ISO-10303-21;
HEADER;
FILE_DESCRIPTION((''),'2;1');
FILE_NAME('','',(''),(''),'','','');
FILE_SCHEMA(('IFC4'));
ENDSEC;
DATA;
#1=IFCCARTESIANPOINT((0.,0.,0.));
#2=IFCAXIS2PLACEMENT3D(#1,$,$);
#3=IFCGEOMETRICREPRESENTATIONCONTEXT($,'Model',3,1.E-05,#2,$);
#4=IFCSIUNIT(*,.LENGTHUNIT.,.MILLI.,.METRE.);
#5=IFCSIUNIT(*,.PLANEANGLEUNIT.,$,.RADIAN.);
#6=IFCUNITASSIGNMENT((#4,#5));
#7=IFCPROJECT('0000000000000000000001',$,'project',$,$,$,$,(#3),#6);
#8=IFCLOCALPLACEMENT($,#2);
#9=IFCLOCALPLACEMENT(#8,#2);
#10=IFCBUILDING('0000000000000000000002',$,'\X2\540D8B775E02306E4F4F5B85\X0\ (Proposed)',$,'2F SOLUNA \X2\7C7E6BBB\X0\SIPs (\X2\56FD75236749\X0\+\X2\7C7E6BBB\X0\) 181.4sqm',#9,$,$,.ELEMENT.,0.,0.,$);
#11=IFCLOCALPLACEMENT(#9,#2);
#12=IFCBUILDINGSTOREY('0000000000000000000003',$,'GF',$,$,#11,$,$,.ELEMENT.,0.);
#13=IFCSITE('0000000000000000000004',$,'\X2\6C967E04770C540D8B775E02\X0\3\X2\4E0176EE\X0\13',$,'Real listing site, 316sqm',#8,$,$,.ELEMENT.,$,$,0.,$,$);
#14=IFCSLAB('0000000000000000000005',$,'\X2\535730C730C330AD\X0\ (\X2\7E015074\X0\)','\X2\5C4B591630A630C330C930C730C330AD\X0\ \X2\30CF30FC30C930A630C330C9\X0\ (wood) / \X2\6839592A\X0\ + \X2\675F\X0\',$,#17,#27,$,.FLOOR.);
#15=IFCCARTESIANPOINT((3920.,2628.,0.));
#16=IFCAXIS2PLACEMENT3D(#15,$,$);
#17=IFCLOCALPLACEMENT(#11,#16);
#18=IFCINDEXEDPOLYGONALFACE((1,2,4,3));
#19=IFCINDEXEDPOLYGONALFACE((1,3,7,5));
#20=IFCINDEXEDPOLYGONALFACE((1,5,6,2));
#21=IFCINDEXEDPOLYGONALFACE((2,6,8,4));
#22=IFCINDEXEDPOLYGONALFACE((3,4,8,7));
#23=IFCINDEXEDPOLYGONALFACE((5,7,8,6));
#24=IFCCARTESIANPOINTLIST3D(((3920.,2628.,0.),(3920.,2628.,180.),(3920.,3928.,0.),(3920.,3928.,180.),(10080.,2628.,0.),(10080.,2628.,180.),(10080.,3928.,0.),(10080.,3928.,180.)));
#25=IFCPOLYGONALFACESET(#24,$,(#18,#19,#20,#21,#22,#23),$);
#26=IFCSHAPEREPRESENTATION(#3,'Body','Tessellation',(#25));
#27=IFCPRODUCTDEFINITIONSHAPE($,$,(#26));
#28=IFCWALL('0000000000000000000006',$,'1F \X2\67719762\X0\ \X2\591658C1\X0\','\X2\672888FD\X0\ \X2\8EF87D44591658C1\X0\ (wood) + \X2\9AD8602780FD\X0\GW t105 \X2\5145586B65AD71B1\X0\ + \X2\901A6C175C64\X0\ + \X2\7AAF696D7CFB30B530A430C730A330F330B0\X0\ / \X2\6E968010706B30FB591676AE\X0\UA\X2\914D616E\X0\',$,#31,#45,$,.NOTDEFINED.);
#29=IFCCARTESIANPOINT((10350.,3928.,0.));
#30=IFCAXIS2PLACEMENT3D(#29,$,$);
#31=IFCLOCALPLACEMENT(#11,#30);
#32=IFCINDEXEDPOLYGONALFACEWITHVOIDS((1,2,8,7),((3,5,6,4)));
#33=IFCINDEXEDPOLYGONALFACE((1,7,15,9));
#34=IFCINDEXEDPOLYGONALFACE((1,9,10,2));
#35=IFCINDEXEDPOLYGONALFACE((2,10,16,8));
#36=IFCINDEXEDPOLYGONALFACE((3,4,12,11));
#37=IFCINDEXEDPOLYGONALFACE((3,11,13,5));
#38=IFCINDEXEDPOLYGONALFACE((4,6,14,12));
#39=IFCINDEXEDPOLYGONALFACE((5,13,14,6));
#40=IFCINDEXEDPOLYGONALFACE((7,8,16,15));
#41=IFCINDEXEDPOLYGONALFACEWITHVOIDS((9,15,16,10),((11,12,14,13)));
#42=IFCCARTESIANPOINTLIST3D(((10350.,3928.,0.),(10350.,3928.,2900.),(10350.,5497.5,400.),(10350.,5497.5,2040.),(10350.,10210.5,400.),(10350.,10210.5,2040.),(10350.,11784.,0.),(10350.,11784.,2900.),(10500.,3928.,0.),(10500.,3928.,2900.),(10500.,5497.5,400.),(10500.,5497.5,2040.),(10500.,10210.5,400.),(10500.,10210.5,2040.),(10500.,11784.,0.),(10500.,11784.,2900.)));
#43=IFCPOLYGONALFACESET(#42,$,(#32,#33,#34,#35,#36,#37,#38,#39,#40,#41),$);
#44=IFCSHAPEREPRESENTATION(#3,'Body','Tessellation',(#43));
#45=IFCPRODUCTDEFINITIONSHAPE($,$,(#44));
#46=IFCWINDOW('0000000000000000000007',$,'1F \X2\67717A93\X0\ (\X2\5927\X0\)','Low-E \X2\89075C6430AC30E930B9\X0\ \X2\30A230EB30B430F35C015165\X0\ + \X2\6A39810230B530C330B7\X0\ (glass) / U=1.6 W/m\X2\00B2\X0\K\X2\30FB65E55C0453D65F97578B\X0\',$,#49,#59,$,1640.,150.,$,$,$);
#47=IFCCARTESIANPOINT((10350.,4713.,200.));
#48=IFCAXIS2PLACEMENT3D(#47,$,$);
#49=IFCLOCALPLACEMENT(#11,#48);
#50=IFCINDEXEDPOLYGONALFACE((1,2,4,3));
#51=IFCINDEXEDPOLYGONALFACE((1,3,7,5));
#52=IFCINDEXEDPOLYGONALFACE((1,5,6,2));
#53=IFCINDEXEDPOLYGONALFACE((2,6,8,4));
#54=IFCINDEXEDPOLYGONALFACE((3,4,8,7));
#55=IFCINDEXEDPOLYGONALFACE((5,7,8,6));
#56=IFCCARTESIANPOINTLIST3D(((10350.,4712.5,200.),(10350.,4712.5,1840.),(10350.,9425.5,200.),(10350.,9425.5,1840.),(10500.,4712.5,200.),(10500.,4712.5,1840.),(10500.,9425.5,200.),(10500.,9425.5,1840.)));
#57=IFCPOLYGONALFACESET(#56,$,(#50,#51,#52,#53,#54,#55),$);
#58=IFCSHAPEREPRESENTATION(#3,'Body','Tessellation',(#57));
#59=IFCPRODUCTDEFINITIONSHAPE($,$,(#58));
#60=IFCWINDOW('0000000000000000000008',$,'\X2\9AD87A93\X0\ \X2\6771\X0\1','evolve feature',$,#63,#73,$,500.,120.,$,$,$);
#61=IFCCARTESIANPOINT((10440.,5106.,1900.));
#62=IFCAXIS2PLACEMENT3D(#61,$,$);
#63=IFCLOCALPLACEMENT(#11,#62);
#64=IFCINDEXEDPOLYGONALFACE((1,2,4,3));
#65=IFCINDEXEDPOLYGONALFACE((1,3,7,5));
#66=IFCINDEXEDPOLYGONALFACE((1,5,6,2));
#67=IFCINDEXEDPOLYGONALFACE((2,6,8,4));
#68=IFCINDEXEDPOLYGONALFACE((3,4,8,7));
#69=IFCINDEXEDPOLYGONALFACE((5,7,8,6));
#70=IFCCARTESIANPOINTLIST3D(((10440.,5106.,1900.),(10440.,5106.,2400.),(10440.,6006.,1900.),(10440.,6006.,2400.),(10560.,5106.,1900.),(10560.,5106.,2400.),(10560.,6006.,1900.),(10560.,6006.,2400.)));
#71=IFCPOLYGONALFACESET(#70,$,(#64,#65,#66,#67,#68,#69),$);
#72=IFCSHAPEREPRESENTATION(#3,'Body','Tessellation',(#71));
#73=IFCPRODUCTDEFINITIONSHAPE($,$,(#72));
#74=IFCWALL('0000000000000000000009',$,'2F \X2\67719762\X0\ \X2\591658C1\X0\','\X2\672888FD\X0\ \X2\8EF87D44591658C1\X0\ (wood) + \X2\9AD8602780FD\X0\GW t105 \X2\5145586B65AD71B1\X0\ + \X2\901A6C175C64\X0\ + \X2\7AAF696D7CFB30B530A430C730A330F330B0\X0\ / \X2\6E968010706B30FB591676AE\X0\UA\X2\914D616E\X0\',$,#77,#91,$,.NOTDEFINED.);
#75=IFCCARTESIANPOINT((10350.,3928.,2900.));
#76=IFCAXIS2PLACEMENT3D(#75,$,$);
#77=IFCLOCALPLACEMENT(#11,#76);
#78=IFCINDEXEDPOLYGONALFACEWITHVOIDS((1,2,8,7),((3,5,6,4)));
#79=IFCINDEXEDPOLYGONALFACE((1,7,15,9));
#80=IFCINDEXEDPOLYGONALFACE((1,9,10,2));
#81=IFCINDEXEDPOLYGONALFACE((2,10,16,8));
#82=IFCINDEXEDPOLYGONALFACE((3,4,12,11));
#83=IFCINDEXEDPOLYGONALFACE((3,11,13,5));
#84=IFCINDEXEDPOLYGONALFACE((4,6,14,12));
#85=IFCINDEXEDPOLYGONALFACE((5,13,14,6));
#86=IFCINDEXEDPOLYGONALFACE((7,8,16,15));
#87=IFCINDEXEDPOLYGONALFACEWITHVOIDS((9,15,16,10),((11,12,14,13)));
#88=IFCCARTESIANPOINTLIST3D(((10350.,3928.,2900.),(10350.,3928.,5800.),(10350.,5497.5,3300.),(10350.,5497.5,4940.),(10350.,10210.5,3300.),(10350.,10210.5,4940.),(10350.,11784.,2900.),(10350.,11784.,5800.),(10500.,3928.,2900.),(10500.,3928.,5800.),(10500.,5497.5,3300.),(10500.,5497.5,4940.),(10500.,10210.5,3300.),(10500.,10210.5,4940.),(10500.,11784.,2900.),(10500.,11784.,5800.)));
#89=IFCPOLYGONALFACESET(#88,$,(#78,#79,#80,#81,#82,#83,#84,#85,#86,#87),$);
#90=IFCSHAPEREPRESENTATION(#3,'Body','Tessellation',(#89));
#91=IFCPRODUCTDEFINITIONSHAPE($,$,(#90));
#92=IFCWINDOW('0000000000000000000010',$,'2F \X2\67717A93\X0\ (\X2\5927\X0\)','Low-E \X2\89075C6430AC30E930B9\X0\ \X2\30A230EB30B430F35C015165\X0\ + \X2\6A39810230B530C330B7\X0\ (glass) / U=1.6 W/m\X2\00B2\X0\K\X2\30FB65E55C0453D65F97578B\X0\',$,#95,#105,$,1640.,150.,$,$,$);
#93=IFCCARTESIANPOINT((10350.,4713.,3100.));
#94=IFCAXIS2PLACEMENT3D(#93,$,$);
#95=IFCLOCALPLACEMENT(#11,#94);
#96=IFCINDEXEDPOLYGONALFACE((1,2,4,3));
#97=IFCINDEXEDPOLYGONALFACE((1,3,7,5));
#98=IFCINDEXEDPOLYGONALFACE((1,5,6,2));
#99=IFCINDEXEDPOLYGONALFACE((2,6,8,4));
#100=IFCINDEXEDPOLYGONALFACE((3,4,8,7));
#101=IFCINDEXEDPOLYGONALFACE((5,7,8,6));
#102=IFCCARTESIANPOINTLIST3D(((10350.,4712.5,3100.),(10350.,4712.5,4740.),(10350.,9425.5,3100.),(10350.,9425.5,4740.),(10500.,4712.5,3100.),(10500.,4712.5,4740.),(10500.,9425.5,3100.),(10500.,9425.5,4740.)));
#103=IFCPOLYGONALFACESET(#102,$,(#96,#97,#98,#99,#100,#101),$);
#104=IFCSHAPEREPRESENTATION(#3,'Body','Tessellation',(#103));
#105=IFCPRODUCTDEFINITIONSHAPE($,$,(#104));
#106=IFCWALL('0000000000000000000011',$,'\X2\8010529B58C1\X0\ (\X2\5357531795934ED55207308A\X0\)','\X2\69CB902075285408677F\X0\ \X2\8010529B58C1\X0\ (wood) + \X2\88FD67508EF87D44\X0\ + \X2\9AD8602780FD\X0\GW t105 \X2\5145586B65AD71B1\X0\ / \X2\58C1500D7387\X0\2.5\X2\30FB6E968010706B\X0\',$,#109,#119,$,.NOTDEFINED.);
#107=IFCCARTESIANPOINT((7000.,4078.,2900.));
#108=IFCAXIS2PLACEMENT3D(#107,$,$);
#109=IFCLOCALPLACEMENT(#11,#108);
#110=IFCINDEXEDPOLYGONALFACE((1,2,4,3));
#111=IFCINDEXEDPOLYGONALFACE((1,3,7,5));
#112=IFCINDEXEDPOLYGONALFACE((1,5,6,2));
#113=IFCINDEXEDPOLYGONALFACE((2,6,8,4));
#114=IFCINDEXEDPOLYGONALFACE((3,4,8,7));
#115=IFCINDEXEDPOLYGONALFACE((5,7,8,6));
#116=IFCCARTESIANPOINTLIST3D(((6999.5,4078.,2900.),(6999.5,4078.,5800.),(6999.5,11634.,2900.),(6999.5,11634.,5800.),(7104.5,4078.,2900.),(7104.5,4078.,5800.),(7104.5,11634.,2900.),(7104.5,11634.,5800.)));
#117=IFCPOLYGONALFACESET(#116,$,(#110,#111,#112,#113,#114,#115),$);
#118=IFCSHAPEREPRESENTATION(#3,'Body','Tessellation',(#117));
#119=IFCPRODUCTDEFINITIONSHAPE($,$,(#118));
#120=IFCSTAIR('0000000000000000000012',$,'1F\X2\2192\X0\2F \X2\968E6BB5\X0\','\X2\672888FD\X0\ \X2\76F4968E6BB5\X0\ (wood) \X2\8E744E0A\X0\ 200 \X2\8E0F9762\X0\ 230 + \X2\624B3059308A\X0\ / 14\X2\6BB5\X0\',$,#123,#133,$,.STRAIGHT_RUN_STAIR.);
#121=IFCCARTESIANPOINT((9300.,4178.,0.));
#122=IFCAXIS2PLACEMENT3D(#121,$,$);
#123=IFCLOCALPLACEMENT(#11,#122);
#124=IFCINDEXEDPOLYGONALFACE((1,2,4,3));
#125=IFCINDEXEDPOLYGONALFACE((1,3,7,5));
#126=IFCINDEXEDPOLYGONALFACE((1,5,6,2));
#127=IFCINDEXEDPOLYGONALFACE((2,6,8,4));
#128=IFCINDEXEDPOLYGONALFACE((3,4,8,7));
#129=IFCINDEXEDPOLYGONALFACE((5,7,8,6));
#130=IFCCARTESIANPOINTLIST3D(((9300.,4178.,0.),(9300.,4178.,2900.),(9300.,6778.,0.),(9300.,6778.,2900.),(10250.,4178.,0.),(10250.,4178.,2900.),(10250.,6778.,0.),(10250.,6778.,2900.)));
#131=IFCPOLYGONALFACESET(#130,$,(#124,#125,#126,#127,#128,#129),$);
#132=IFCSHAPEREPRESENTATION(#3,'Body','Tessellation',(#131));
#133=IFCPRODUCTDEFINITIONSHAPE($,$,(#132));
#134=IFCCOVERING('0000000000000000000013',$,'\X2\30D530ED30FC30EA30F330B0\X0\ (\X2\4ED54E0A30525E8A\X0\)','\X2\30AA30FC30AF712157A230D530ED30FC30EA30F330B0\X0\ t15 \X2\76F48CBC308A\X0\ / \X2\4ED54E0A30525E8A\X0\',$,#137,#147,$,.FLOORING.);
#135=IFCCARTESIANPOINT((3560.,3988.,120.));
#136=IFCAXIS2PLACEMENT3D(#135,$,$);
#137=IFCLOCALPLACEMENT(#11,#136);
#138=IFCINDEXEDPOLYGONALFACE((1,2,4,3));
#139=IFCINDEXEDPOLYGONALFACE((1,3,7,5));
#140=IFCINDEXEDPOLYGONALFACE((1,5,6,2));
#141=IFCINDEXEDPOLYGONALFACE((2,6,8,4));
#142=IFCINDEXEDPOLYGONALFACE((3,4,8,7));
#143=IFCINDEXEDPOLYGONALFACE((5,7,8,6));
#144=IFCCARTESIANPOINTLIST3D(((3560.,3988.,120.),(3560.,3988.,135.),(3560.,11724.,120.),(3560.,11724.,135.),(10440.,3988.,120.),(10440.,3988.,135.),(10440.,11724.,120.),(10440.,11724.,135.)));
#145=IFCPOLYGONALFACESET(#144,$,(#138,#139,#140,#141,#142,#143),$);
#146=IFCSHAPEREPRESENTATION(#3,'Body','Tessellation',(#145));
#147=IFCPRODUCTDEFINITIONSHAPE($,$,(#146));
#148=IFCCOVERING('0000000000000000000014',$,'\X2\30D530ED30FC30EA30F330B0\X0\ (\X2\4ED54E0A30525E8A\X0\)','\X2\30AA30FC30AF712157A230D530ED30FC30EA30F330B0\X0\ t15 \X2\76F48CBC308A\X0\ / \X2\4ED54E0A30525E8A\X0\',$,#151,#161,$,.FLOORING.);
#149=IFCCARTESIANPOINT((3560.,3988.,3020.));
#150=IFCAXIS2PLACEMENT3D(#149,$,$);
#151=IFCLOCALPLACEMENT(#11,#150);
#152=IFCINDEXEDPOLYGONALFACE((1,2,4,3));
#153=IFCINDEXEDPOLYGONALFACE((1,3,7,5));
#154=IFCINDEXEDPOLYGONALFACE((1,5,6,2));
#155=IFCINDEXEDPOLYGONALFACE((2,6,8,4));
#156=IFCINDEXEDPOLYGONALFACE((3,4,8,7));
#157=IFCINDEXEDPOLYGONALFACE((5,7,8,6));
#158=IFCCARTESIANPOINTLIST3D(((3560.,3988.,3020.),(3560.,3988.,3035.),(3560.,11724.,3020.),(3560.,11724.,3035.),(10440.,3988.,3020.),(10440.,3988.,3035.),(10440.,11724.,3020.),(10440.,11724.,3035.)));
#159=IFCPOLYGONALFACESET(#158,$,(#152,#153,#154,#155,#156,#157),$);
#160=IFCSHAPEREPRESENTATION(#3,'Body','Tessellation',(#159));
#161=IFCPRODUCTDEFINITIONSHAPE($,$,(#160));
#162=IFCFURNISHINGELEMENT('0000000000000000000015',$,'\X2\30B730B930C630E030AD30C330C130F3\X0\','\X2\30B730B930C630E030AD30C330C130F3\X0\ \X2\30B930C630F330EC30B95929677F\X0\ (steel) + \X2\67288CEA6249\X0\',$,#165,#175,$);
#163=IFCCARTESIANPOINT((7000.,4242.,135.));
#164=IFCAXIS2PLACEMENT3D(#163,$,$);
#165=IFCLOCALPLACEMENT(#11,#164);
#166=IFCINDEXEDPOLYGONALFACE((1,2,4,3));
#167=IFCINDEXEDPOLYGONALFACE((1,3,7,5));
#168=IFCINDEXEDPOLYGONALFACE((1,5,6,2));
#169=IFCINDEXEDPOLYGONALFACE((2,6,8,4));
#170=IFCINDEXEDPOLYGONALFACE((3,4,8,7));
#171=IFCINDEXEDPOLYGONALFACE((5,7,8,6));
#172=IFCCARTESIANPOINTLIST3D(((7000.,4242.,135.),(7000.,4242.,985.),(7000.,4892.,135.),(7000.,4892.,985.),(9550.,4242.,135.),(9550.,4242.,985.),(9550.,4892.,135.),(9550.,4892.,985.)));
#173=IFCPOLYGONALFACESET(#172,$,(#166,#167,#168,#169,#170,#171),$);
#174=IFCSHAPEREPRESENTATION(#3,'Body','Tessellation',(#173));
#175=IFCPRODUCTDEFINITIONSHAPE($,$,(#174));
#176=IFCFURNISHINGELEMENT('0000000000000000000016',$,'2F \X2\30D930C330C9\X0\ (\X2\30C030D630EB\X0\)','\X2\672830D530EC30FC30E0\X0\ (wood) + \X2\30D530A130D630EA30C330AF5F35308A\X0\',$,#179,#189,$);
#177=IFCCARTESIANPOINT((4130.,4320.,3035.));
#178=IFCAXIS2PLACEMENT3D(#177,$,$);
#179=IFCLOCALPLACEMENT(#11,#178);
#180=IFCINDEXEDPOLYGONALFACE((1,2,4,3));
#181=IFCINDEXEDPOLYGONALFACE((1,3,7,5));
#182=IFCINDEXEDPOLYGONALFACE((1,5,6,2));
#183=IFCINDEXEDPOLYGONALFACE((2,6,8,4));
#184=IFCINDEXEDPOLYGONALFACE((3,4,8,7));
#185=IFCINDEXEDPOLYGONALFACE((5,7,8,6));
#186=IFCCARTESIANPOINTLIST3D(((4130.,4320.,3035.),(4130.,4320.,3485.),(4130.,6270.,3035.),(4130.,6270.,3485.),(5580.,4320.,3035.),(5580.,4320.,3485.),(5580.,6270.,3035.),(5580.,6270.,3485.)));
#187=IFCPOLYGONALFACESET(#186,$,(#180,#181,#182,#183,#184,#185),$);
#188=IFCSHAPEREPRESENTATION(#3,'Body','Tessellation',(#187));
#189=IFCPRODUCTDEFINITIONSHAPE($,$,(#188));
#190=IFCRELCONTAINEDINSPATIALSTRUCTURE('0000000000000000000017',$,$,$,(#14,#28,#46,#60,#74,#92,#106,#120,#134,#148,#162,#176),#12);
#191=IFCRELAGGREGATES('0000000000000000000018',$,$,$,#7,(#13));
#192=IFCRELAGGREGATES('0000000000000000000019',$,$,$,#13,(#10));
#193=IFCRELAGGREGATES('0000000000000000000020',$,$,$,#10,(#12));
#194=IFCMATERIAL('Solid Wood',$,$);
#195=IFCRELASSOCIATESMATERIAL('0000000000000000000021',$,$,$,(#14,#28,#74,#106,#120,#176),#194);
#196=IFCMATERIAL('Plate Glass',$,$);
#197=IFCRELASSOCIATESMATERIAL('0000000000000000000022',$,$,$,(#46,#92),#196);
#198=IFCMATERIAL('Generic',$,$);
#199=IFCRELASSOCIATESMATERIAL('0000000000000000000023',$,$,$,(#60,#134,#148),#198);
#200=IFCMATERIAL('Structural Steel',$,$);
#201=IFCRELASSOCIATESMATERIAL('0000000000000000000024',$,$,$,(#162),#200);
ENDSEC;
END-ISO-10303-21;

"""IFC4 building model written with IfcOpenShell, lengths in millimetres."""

from ifc_helpers import new_model, si_unit, frame, frame_2d, origin, place, context, project, spatial, rectangle, extrude, material, element, fill, save


model = new_model("IFC4")

# Units and contexts
model_context = context("Model", 3, precision=1e-05, world=origin())
ifc_project = project(units=[si_unit("LENGTHUNIT", "METRE", prefix="MILLI"), si_unit("PLANEANGLEUNIT", "RADIAN")], contexts=[model_context])

# Site, building, storey
site_placement = place(None, origin())
site = spatial("IfcSite", under=ifc_project, at=site_placement, Name="沖縄県名護市3丁目13", ObjectType="Real listing site, 316sqm", CompositionType="ELEMENT", RefElevation=0.0)
building_placement = place(site_placement, origin())
building = spatial("IfcBuilding", under=site, at=building_placement, Name="名護市の住宅 (Proposed)", ObjectType="2F SOLUNA 籾殻SIPs (国産杉+籾殻) 181.4sqm", CompositionType="ELEMENT", ElevationOfRefHeight=0.0, ElevationOfTerrain=0.0)
storey_placement = place(building_placement, origin())
storey = spatial("IfcBuildingStorey", under=building, at=storey_placement, Name="GF", CompositionType="ELEMENT", Elevation=0.0)

# Slab
ifc_material_1 = material(Name="Solid Wood")
slab_placement = place(storey_placement, frame((3920.0, 2628.0, 0.0)))
element("IfcSlab", 1, at=slab_placement, inside=storey, material=ifc_material_1, Name="南デッキ (縁側)", Description="屋外ウッドデッキ ハードウッド (wood) / 根太 + 束", PredefinedType="FLOOR", context=model_context, shape_type="SweptSolid", body=[
    extrude(rectangle(XDim=6160.0, YDim=1300.0, at=frame_2d((3080.0, 650.0))), frame((3920.0, 2628.0, 0.0)), (0.0, 0.0, 1.0), 180.0),
])

# Wall, openings, windows
wall_1_placement = place(storey_placement, frame((10350.0, 3928.0, 0.0)))
wall_1 = element("IfcWall", 2, at=wall_1_placement, inside=storey, material=ifc_material_1, Name="1F 東面 外壁", Description="木製 軸組外壁 (wood) + 高性能GW t105 充填断熱 + 通気層 + 窯業系サイディング / 準耐火・外皮UA配慮", PredefinedType="NOTDEFINED", context=model_context, shape_type="SweptSolid", body=[
    extrude(rectangle(XDim=150.0, YDim=7856.0, at=frame_2d((75.0, 3928.0))), frame((10350.0, 3928.0, 0.0)), (0.0, 0.0, 1.0), 2900.0),
])
opening_1_placement = place(storey_placement, frame((10350.0, 4713.0, 200.0)))
opening_1 = element("IfcOpeningElement", 3, at=opening_1_placement, cuts=wall_1, PredefinedType="NOTDEFINED", context=model_context, shape_type="SweptSolid", body=[
    extrude(rectangle(XDim=150.0, YDim=4713.0, at=frame_2d((75.0, 2356.0))), frame((10350.0, 4713.0, 200.0)), (0.0, 0.0, 1.0), 1640.0),
])
opening_2_placement = place(storey_placement, frame((10440.0, 5106.0, 1900.0)))
opening_2 = element("IfcOpeningElement", 4, at=opening_2_placement, cuts=wall_1, PredefinedType="NOTDEFINED", context=model_context, shape_type="SweptSolid", body=[
    extrude(rectangle(XDim=120.0, YDim=900.0, at=frame_2d((60.0, 450.0))), frame((10440.0, 5106.0, 1900.0)), (0.0, 0.0, 1.0), 500.0),
])
ifc_material_2 = material(Name="Plate Glass")
window_1_placement = place(storey_placement, frame((10350.0, 4713.0, 200.0)))
window_1 = element("IfcWindow", 5, at=window_1_placement, inside=storey, material=ifc_material_2, Name="1F 東窓 (大)", Description="Low-E 複層ガラス アルゴン封入 + 樹脂サッシ (glass) / U=1.6 W/m²K・日射取得型", OverallHeight=1640.0, OverallWidth=150.0, context=model_context, shape_type="SweptSolid", body=[
    extrude(rectangle(XDim=150.0, YDim=4713.0, at=frame_2d((75.0, 2356.0))), frame((10350.0, 4713.0, 200.0)), (0.0, 0.0, 1.0), 1640.0),
])
fill(opening_1, window_1)
ifc_material_3 = material(Name="Generic")
window_2_placement = place(storey_placement, frame((10440.0, 5106.0, 1900.0)))
window_2 = element("IfcWindow", 6, at=window_2_placement, inside=storey, material=ifc_material_3, Name="高窓 東1", Description="evolve feature", OverallHeight=500.0, OverallWidth=120.0, context=model_context, shape_type="SweptSolid", body=[
    extrude(rectangle(XDim=120.0, YDim=900.0, at=frame_2d((60.0, 450.0))), frame((10440.0, 5106.0, 1900.0)), (0.0, 0.0, 1.0), 500.0),
])
fill(opening_2, window_2)

# Wall, opening, window
wall_2_placement = place(storey_placement, frame((10350.0, 3928.0, 2900.0)))
wall_2 = element("IfcWall", 7, at=wall_2_placement, inside=storey, material=ifc_material_1, Name="2F 東面 外壁", Description="木製 軸組外壁 (wood) + 高性能GW t105 充填断熱 + 通気層 + 窯業系サイディング / 準耐火・外皮UA配慮", PredefinedType="NOTDEFINED", context=model_context, shape_type="SweptSolid", body=[
    extrude(rectangle(XDim=150.0, YDim=7856.0, at=frame_2d((75.0, 3928.0))), frame((10350.0, 3928.0, 2900.0)), (0.0, 0.0, 1.0), 2900.0),
])
opening_3_placement = place(storey_placement, frame((10350.0, 4713.0, 3100.0)))
opening_3 = element("IfcOpeningElement", 8, at=opening_3_placement, cuts=wall_2, PredefinedType="NOTDEFINED", context=model_context, shape_type="SweptSolid", body=[
    extrude(rectangle(XDim=150.0, YDim=4713.0, at=frame_2d((75.0, 2356.0))), frame((10350.0, 4713.0, 3100.0)), (0.0, 0.0, 1.0), 1640.0),
])
window_3_placement = place(storey_placement, frame((10350.0, 4713.0, 3100.0)))
window_3 = element("IfcWindow", 9, at=window_3_placement, inside=storey, material=ifc_material_2, Name="2F 東窓 (大)", Description="Low-E 複層ガラス アルゴン封入 + 樹脂サッシ (glass) / U=1.6 W/m²K・日射取得型", OverallHeight=1640.0, OverallWidth=150.0, context=model_context, shape_type="SweptSolid", body=[
    extrude(rectangle(XDim=150.0, YDim=4713.0, at=frame_2d((75.0, 2356.0))), frame((10350.0, 4713.0, 3100.0)), (0.0, 0.0, 1.0), 1640.0),
])
fill(opening_3, window_3)

# Wall
wall_3_placement = place(storey_placement, frame((7000.0, 4078.0, 2900.0)))
element("IfcWall", 10, at=wall_3_placement, inside=storey, material=ifc_material_1, Name="耐力壁 (南北間仕切り)", Description="構造用合板 耐力壁 (wood) + 製材軸組 + 高性能GW t105 充填断熱 / 壁倍率2.5・準耐火", PredefinedType="NOTDEFINED", context=model_context, shape_type="SweptSolid", body=[
    extrude(rectangle(XDim=105.0, YDim=7556.0, at=frame_2d((52.0, 3778.0))), frame((7000.0, 4078.0, 2900.0)), (0.0, 0.0, 1.0), 2900.0),
])

# Stair
stair_placement = place(storey_placement, frame((9300.0, 4178.0, 0.0)))
element("IfcStair", 11, at=stair_placement, inside=storey, material=ifc_material_1, Name="1F→2F 階段", Description="木製 直階段 (wood) 蹴上 200 踏面 230 + 手すり / 14段", PredefinedType="STRAIGHT_RUN_STAIR", context=model_context, shape_type="SweptSolid", body=[
    extrude(rectangle(XDim=950.0, YDim=2600.0, at=frame_2d((475.0, 1300.0))), frame((9300.0, 4178.0, 0.0)), (0.0, 0.0, 1.0), 2900.0),
])

# Coverings
covering_1_placement = place(storey_placement, frame((3560.0, 3988.0, 120.0)))
element("IfcCovering", 12, at=covering_1_placement, inside=storey, material=ifc_material_3, Name="フローリング (仕上げ床)", Description="オーク無垢フローリング t15 直貼り / 仕上げ床", PredefinedType="FLOORING", context=model_context, shape_type="SweptSolid", body=[
    extrude(rectangle(XDim=6880.0, YDim=7736.0, at=frame_2d((3440.0, 3868.0))), frame((3560.0, 3988.0, 120.0)), (0.0, 0.0, 1.0), 15.0),
])
covering_2_placement = place(storey_placement, frame((3560.0, 3988.0, 3020.0)))
element("IfcCovering", 13, at=covering_2_placement, inside=storey, material=ifc_material_3, Name="フローリング (仕上げ床)", Description="オーク無垢フローリング t15 直貼り / 仕上げ床", PredefinedType="FLOORING", context=model_context, shape_type="SweptSolid", body=[
    extrude(rectangle(XDim=6880.0, YDim=7736.0, at=frame_2d((3440.0, 3868.0))), frame((3560.0, 3988.0, 3020.0)), (0.0, 0.0, 1.0), 15.0),
])

# Furnishing elements
ifc_material_4 = material(Name="Structural Steel")
furnishing_1_placement = place(storey_placement, frame((7000.0, 4242.0, 135.0)))
element("IfcFurnishingElement", 14, at=furnishing_1_placement, inside=storey, material=ifc_material_4, Name="システムキッチン", Description="システムキッチン ステンレス天板 (steel) + 木質扉", context=model_context, shape_type="SweptSolid", body=[
    extrude(rectangle(XDim=2550.0, YDim=650.0, at=frame_2d((1275.0, 325.0))), frame((7000.0, 4242.0, 135.0)), (0.0, 0.0, 1.0), 850.0),
])
furnishing_2_placement = place(storey_placement, frame((4130.0, 4320.0, 3035.0)))
element("IfcFurnishingElement", 15, at=furnishing_2_placement, inside=storey, material=ifc_material_1, Name="2F ベッド (ダブル)", Description="木フレーム (wood) + ファブリック張り", context=model_context, shape_type="SweptSolid", body=[
    extrude(rectangle(XDim=1450.0, YDim=1950.0, at=frame_2d((725.0, 975.0))), frame((4130.0, 4320.0, 3035.0)), (0.0, 0.0, 1.0), 450.0),
])

save(model, "model.ifc")
